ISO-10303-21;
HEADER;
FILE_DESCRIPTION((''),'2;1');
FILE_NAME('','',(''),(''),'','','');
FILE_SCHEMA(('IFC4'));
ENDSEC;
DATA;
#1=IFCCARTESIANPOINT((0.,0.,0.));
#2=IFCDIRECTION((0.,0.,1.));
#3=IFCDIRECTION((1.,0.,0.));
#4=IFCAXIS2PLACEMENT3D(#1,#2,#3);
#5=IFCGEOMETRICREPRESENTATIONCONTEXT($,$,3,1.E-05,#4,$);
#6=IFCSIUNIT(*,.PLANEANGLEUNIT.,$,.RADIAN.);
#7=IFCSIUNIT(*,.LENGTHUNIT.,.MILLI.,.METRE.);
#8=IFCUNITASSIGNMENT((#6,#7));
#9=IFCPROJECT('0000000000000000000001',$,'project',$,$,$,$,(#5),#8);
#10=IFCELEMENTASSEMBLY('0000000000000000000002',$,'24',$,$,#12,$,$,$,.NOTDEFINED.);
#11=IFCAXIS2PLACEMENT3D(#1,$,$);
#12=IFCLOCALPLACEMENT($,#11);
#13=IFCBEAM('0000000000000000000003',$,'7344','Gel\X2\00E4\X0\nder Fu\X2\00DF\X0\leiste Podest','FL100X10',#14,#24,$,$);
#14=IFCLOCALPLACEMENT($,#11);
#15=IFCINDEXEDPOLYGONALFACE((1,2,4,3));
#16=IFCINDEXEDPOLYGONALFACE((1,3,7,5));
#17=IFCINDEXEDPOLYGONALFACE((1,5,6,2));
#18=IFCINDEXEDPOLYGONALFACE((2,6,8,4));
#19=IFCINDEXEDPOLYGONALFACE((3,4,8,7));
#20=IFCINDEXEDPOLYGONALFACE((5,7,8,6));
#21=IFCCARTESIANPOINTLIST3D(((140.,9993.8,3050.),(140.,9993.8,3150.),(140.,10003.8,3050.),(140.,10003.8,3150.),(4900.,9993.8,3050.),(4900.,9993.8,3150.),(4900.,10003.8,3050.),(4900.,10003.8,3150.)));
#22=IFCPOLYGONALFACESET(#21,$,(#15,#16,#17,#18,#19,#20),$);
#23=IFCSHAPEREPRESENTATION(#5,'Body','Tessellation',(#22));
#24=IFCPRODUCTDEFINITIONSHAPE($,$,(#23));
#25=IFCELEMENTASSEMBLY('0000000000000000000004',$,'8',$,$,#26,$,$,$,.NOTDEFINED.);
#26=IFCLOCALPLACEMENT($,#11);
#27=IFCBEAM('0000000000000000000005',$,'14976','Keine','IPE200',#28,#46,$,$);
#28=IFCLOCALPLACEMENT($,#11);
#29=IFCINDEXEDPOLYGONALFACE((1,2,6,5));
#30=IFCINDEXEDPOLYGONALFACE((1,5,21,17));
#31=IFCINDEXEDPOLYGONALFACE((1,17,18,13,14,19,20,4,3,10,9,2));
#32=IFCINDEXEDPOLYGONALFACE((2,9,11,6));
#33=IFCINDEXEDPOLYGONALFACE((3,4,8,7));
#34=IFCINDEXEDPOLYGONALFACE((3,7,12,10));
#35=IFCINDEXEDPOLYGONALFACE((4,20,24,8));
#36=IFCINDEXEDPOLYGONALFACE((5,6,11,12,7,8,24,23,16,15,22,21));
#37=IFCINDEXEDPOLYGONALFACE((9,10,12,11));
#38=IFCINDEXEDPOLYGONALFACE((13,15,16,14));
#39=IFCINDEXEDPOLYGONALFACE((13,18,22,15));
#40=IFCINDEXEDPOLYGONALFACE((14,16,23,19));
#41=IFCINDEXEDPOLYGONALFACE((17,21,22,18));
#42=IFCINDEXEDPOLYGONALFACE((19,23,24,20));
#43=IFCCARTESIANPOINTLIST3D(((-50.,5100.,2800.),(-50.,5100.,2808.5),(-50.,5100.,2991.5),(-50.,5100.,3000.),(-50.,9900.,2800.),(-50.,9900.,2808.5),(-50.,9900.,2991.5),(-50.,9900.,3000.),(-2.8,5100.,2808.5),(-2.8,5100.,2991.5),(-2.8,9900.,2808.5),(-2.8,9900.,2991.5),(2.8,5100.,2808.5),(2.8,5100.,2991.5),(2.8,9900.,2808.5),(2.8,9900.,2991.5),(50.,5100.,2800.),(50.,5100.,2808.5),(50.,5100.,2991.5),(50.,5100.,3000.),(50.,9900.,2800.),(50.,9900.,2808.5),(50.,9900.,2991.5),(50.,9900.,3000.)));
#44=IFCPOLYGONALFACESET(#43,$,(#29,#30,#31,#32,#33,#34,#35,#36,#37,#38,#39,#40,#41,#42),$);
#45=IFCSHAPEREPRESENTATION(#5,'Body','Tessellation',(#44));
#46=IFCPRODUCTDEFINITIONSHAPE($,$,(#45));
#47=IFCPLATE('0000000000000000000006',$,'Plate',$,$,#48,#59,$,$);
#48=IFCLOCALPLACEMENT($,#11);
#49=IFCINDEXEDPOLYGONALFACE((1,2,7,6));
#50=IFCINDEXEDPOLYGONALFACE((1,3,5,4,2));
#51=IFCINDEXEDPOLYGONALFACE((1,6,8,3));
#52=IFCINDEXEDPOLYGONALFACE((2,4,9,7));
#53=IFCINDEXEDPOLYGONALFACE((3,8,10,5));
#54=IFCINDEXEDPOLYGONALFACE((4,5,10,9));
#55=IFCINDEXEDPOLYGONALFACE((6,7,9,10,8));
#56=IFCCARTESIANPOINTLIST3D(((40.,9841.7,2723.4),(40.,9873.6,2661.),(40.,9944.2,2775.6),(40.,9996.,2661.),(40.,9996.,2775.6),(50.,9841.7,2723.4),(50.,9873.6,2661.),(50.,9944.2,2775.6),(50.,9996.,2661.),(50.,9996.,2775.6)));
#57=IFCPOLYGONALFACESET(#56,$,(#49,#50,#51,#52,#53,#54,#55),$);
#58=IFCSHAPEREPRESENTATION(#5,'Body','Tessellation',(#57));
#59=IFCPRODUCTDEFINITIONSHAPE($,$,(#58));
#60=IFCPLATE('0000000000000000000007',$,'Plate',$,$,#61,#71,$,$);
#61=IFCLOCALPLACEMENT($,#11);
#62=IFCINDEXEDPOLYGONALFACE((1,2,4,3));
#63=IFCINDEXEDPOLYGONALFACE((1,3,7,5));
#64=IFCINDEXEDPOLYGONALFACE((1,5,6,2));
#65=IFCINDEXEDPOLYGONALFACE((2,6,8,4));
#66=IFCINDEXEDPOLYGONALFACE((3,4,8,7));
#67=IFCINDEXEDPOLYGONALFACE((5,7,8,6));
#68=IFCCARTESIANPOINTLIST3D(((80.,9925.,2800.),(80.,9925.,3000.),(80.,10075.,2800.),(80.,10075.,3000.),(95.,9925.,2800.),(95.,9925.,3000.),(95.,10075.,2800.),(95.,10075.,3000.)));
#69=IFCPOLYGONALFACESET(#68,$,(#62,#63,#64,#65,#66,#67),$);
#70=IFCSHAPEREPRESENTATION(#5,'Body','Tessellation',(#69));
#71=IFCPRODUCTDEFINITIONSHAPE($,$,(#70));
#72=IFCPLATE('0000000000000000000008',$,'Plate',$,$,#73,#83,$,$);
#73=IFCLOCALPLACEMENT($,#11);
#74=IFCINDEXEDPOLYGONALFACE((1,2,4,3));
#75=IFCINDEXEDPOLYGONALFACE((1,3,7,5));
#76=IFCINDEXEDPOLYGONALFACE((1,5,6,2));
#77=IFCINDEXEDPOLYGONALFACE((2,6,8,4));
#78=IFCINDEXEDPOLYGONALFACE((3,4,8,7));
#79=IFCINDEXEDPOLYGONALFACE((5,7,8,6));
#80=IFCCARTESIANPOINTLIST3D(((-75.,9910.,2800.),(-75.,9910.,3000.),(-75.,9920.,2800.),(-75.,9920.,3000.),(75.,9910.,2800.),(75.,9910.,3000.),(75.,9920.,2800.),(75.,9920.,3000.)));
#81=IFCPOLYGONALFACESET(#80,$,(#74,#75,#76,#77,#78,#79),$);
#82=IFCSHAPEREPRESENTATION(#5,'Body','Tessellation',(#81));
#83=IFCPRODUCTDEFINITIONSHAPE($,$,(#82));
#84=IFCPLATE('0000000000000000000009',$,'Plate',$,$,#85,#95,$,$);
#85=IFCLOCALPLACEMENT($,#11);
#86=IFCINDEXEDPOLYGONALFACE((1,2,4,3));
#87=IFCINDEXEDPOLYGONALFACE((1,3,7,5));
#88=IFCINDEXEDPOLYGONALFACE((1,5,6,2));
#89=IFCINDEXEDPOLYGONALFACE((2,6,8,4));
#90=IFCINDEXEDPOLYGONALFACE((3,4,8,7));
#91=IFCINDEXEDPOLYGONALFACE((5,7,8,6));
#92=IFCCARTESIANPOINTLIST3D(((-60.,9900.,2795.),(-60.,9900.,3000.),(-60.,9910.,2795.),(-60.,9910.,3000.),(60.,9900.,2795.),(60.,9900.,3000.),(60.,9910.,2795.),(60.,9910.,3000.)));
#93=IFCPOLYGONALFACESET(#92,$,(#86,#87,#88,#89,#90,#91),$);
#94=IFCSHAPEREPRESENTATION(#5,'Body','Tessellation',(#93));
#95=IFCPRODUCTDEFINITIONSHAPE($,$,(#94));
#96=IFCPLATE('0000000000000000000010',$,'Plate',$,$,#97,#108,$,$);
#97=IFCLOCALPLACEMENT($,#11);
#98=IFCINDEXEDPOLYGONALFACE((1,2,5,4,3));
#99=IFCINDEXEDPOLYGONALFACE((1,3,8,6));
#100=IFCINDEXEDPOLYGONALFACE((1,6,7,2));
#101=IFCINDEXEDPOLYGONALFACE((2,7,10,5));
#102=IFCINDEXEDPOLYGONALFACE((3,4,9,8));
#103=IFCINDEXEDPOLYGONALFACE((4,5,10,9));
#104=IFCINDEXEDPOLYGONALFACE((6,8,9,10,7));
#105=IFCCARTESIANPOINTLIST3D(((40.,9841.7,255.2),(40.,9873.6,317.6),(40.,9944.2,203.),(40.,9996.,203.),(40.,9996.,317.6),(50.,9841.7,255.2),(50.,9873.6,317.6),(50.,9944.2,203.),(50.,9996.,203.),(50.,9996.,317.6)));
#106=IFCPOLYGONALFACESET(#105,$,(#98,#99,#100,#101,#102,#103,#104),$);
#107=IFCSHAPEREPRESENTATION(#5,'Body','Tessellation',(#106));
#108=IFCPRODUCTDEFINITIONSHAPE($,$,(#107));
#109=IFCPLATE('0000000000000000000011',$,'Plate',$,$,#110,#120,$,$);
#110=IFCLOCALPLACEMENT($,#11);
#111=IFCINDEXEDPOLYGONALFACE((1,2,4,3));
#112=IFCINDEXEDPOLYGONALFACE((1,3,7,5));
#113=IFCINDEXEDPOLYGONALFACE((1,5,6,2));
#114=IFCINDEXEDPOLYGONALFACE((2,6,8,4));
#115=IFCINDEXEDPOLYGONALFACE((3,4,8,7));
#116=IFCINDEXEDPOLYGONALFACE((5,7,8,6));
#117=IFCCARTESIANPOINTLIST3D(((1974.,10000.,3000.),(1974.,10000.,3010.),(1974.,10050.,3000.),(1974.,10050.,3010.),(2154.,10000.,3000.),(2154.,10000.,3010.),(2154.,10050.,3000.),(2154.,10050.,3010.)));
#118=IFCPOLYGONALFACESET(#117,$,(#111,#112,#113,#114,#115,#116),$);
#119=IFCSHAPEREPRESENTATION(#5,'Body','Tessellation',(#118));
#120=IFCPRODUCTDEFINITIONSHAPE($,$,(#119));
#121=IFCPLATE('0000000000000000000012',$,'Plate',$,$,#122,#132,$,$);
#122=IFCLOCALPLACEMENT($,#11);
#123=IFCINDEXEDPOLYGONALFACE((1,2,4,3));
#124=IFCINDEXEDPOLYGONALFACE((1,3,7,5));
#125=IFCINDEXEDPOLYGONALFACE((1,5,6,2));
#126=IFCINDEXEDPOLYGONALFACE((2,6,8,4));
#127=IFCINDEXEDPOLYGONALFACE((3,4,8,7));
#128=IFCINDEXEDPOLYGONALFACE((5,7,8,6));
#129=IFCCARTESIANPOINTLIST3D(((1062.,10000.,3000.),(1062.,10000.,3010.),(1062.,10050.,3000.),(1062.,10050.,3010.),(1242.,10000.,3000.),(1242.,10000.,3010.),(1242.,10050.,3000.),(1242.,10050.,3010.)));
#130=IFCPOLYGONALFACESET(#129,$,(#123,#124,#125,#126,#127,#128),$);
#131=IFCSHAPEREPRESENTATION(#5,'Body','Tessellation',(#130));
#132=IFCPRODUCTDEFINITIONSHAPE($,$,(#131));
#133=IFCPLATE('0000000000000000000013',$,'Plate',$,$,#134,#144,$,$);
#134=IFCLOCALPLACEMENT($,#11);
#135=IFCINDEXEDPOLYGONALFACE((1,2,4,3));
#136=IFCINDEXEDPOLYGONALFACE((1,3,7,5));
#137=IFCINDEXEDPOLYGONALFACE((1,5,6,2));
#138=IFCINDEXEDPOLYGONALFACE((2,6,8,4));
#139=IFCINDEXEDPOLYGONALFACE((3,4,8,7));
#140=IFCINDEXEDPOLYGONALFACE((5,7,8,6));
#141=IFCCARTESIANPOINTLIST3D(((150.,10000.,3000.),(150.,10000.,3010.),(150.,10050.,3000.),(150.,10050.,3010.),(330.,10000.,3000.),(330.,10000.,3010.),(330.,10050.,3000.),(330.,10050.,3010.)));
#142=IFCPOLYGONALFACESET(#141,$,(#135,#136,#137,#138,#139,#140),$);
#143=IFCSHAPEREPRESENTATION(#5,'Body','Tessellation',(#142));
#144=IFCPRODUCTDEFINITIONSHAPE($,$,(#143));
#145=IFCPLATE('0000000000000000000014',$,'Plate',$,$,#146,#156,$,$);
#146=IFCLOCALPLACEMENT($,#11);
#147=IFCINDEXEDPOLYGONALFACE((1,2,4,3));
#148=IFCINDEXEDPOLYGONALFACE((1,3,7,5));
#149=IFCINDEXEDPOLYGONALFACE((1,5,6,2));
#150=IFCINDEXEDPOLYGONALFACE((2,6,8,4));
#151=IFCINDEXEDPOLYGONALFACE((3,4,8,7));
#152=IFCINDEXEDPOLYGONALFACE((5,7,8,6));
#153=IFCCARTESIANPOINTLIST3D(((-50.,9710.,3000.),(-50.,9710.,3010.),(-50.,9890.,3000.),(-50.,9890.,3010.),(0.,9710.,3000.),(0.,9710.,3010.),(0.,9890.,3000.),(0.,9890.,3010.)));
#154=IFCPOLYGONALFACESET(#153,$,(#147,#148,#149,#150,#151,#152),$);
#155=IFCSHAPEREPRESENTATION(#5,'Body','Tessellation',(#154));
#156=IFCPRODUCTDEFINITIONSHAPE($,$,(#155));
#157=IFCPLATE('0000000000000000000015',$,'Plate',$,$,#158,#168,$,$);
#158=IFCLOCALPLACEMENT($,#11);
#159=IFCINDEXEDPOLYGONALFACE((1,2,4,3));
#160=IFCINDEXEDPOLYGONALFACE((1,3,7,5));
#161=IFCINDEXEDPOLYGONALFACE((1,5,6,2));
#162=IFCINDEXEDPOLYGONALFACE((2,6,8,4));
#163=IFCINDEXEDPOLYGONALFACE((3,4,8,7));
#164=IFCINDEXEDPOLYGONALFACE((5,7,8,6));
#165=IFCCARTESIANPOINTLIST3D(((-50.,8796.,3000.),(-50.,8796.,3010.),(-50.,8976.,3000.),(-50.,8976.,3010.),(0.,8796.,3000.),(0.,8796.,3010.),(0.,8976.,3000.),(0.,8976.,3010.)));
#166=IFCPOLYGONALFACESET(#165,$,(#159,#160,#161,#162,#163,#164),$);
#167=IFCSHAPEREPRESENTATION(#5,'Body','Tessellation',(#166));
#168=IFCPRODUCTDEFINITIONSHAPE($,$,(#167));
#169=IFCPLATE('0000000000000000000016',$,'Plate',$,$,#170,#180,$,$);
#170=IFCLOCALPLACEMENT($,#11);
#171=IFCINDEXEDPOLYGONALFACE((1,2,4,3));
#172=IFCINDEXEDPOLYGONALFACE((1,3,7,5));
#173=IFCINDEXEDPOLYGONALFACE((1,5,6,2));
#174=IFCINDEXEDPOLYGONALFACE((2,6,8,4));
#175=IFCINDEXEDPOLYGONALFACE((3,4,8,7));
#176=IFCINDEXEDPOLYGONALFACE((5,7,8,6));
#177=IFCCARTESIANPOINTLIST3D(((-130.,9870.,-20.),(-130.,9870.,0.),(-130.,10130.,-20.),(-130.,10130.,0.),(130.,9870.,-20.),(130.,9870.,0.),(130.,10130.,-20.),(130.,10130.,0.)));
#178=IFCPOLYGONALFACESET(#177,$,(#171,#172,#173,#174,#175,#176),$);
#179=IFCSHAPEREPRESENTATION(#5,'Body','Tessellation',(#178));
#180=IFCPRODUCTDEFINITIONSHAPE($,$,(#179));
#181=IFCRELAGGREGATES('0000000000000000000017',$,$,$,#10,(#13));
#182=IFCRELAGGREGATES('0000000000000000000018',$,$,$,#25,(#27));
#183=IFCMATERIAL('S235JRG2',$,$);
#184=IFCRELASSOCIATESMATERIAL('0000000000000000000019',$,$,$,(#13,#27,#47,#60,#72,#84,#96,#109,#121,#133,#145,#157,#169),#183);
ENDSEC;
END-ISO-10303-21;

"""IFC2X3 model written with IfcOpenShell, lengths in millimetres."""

from ifc_helpers import new_model, si_unit, frame, origin_with_axes, place, context, project, polyline, outline, extrude, clip, halfspace, material, element, aggregate, save


model = new_model("IFC2X3")

# Units and contexts
context_of_model = context(None, 3, precision=1e-05, world=origin_with_axes())
ifc_project = project(units=[si_unit("PLANEANGLEUNIT", "RADIAN"), si_unit("LENGTHUNIT", "METRE", prefix="MILLI")], contexts=[context_of_model])

# Shared definitions
ifc_material = material(Name="S235JRG2")

# Element assembly, beam
assembly_1_placement = place(None, frame((140.0, 9998.8, 6100.0), z_axis=(0.0, 0.0, 1.0), x_axis=(1.0, 0.0, 0.0)))
assembly_1 = element("IfcElementAssembly", 1, at=assembly_1_placement, Name="24", PredefinedType="NOTDEFINED")
placement_1 = place(None, frame((140.0, 9998.8, 3100.0), z_axis=(0.0, 0.0, 1.0), x_axis=(1.0, 0.0, 0.0)))
beam_1_placement = place(placement_1, origin_with_axes())
beam_1 = element("IfcBeam", 2, at=beam_1_placement, material=ifc_material, Name="7344", Description="Geländer Fußleiste Podest", ObjectType="FL100X10", context=context_of_model, shape_type="SweptSolid", body=[
    extrude(outline(polyline([(5.0, -50.0), (5.0, 50.0), (-5.0, 50.0), (-5.0, -50.0), (5.0, -50.0), (5.0, -50.0)])), frame((0.0, 0.0, 0.0), z_axis=(1.0, 0.0, 0.0), x_axis=(0.0, 1.0, 0.0)), (0.0, 0.0, 1.0), 4760.0),
])
aggregate(assembly_1, [beam_1])

# Element assembly, beam
assembly_2_placement = place(None, frame((0.0, 10000.0, 6000.0), z_axis=(0.0, 0.0, 1.0), x_axis=(0.0, -1.0, 0.0)))
assembly_2 = element("IfcElementAssembly", 3, at=assembly_2_placement, Name="8", PredefinedType="NOTDEFINED")
placement_2 = place(None, frame((0.0, 10000.0, 2900.0), z_axis=(0.0, 0.0, 1.0), x_axis=(0.0, -1.0, 0.0)))
beam_2_placement = place(placement_2, origin_with_axes())
beam_2 = element("IfcBeam", 4, at=beam_2_placement, material=ifc_material, Name="14976", Description="Keine", ObjectType="IPE200", context=context_of_model, shape_type="Clipping", body=[
    clip(clip(extrude(outline(polyline([(50.0, -100.0), (50.0, -91.5), (2.8, -91.5), (2.8, 91.5), (50.0, 91.5), (50.0, 100.0), (-50.0, 100.0), (-50.0, 91.5), (-2.8, 91.5), (-2.8, -91.5), (-50.0, -91.5), (-50.0, -100.0), (50.0, -100.0), (50.0, -100.0)])), frame((0.0, 0.0, 0.0), z_axis=(1.0, 0.0, 0.0), x_axis=(0.0, 1.0, 0.0)), (0.0, 0.0, 1.0), 5000.0), halfspace(frame((100.0, 0.0, 100.0), z_axis=(-1.0, 0.0, 0.0), x_axis=(0.0, 0.0, -1.0)), False)), halfspace(frame((4900.0, 0.0, 100.0), z_axis=(1.0, 0.0, 0.0), x_axis=(0.0, 0.0, 1.0)), False)),
])
aggregate(assembly_2, [beam_2])

# Plates
placement_3 = place(None, origin_with_axes())
plate_1_placement = place(placement_3, frame((50.0, 9944.2, 2775.6), z_axis=(0.0, 0.0, -1.0), x_axis=(-1.0, 0.0, 0.0)))
element("IfcPlate", 5, at=plate_1_placement, material=ifc_material, Name="Plate", context=context_of_model, shape_type="SweptSolid", body=[
    extrude(outline(polyline([(0.0, 0.0), (51.8, 0.0), (51.8, 114.6), (-70.6, 114.6), (-102.4, 52.3), (0.0, 0.0)])), frame((0.0, 0.0, 0.0), z_axis=(1.0, 0.0, 0.0), x_axis=(0.0, 1.0, 0.0)), (0.0, 0.0, 1.0), 10.0),
])
placement_4 = place(None, origin_with_axes())
plate_2_placement = place(placement_4, frame((95.0, 9925.0, 2800.0), z_axis=(0.0, 1.0, 0.0), x_axis=(-1.0, 0.0, 0.0)))
element("IfcPlate", 6, at=plate_2_placement, material=ifc_material, Name="Plate", context=context_of_model, shape_type="SweptSolid", body=[
    extrude(outline(polyline([(0.0, 0.0), (200.0, 0.0), (200.0, 150.0), (0.0, 150.0), (0.0, 0.0)])), frame((0.0, 0.0, 0.0), z_axis=(1.0, 0.0, 0.0), x_axis=(0.0, 1.0, 0.0)), (0.0, 0.0, 1.0), 15.0),
])
placement_5 = place(None, origin_with_axes())
plate_3_placement = place(placement_5, frame((75.0, 9920.0, 3000.0), z_axis=(0.0, 0.0, -1.0), x_axis=(0.0, -1.0, 0.0)))
element("IfcPlate", 7, at=plate_3_placement, material=ifc_material, Name="Plate", context=context_of_model, shape_type="SweptSolid", body=[
    extrude(outline(polyline([(0.0, 0.0), (150.0, 0.0), (150.0, 200.0), (0.0, 200.0), (0.0, 0.0)])), frame((0.0, 0.0, 0.0), z_axis=(1.0, 0.0, 0.0), x_axis=(0.0, 1.0, 0.0)), (0.0, 0.0, 1.0), 10.0),
])
placement_6 = place(None, origin_with_axes())
plate_4_placement = place(placement_6, frame((60.0, 9900.0, 2795.0), z_axis=(0.0, 0.0, 1.0), x_axis=(0.0, 1.0, 0.0)))
element("IfcPlate", 8, at=plate_4_placement, material=ifc_material, Name="Plate", context=context_of_model, shape_type="SweptSolid", body=[
    extrude(outline(polyline([(0.0, 0.0), (120.0, 0.0), (120.0, 205.0), (0.0, 205.0), (0.0, 0.0)])), frame((0.0, 0.0, 0.0), z_axis=(1.0, 0.0, 0.0), x_axis=(0.0, 1.0, 0.0)), (0.0, 0.0, 1.0), 10.0),
])
placement_7 = place(None, origin_with_axes())
plate_5_placement = place(placement_7, frame((40.0, 9944.2, 203.0), z_axis=(0.0, 0.0, 1.0), x_axis=(1.0, 0.0, 0.0)))
element("IfcPlate", 9, at=plate_5_placement, material=ifc_material, Name="Plate", context=context_of_model, shape_type="SweptSolid", body=[
    extrude(outline(polyline([(0.0, 0.0), (51.8, 0.0), (51.8, 114.6), (-70.6, 114.6), (-102.4, 52.3), (0.0, 0.0)])), frame((0.0, 0.0, 0.0), z_axis=(1.0, 0.0, 0.0), x_axis=(0.0, 1.0, 0.0)), (0.0, 0.0, 1.0), 10.0),
])
placement_8 = place(None, origin_with_axes())
plate_6_placement = place(placement_8, frame((2154.0, 10000.0, 3010.0), z_axis=(0.0, 1.0, 0.0), x_axis=(0.0, 0.0, -1.0)))
element("IfcPlate", 10, at=plate_6_placement, material=ifc_material, Name="Plate", context=context_of_model, shape_type="SweptSolid", body=[
    extrude(outline(polyline([(0.0, 0.0), (180.0, 0.0), (180.0, 50.0), (0.0, 50.0), (0.0, 0.0)])), frame((0.0, 0.0, 0.0), z_axis=(1.0, 0.0, 0.0), x_axis=(0.0, 1.0, 0.0)), (0.0, 0.0, 1.0), 10.0),
])
placement_9 = place(None, origin_with_axes())
plate_7_placement = place(placement_9, frame((1242.0, 10000.0, 3010.0), z_axis=(0.0, 1.0, 0.0), x_axis=(0.0, 0.0, -1.0)))
element("IfcPlate", 11, at=plate_7_placement, material=ifc_material, Name="Plate", context=context_of_model, shape_type="SweptSolid", body=[
    extrude(outline(polyline([(0.0, 0.0), (180.0, 0.0), (180.0, 50.0), (0.0, 50.0), (0.0, 0.0)])), frame((0.0, 0.0, 0.0), z_axis=(1.0, 0.0, 0.0), x_axis=(0.0, 1.0, 0.0)), (0.0, 0.0, 1.0), 10.0),
])
placement_10 = place(None, origin_with_axes())
plate_8_placement = place(placement_10, frame((330.0, 10000.0, 3010.0), z_axis=(0.0, 1.0, 0.0), x_axis=(0.0, 0.0, -1.0)))
element("IfcPlate", 12, at=plate_8_placement, material=ifc_material, Name="Plate", context=context_of_model, shape_type="SweptSolid", body=[
    extrude(outline(polyline([(0.0, 0.0), (180.0, 0.0), (180.0, 50.0), (0.0, 50.0), (0.0, 0.0)])), frame((0.0, 0.0, 0.0), z_axis=(1.0, 0.0, 0.0), x_axis=(0.0, 1.0, 0.0)), (0.0, 0.0, 1.0), 10.0),
])
placement_11 = place(None, origin_with_axes())
plate_9_placement = place(placement_11, frame((0.0, 9890.0, 3010.0), z_axis=(-1.0, 0.0, 0.0), x_axis=(0.0, 0.0, -1.0)))
element("IfcPlate", 13, at=plate_9_placement, material=ifc_material, Name="Plate", context=context_of_model, shape_type="SweptSolid", body=[
    extrude(outline(polyline([(0.0, 0.0), (180.0, 0.0), (180.0, 50.0), (0.0, 50.0), (0.0, 0.0)])), frame((0.0, 0.0, 0.0), z_axis=(1.0, 0.0, 0.0), x_axis=(0.0, 1.0, 0.0)), (0.0, 0.0, 1.0), 10.0),
])
placement_12 = place(None, origin_with_axes())
plate_10_placement = place(placement_12, frame((0.0, 8976.0, 3010.0), z_axis=(-1.0, 0.0, 0.0), x_axis=(0.0, 0.0, -1.0)))
element("IfcPlate", 14, at=plate_10_placement, material=ifc_material, Name="Plate", context=context_of_model, shape_type="SweptSolid", body=[
    extrude(outline(polyline([(0.0, 0.0), (180.0, 0.0), (180.0, 50.0), (0.0, 50.0), (0.0, 0.0)])), frame((0.0, 0.0, 0.0), z_axis=(1.0, 0.0, 0.0), x_axis=(0.0, 1.0, 0.0)), (0.0, 0.0, 1.0), 10.0),
])
placement_13 = place(None, origin_with_axes())
plate_11_placement = place(placement_13, frame((130.0, 10130.0, 0.0), z_axis=(-1.0, 0.0, 0.0), x_axis=(0.0, 0.0, -1.0)))
element("IfcPlate", 15, at=plate_11_placement, material=ifc_material, Name="Plate", context=context_of_model, shape_type="SweptSolid", body=[
    extrude(outline(polyline([(0.0, 0.0), (260.0, 0.0), (260.0, 260.0), (0.0, 260.0), (0.0, 0.0)])), frame((0.0, 0.0, 0.0), z_axis=(1.0, 0.0, 0.0), x_axis=(0.0, 1.0, 0.0)), (0.0, 0.0, 1.0), 20.0),
])

save(model, "model.ifc")
